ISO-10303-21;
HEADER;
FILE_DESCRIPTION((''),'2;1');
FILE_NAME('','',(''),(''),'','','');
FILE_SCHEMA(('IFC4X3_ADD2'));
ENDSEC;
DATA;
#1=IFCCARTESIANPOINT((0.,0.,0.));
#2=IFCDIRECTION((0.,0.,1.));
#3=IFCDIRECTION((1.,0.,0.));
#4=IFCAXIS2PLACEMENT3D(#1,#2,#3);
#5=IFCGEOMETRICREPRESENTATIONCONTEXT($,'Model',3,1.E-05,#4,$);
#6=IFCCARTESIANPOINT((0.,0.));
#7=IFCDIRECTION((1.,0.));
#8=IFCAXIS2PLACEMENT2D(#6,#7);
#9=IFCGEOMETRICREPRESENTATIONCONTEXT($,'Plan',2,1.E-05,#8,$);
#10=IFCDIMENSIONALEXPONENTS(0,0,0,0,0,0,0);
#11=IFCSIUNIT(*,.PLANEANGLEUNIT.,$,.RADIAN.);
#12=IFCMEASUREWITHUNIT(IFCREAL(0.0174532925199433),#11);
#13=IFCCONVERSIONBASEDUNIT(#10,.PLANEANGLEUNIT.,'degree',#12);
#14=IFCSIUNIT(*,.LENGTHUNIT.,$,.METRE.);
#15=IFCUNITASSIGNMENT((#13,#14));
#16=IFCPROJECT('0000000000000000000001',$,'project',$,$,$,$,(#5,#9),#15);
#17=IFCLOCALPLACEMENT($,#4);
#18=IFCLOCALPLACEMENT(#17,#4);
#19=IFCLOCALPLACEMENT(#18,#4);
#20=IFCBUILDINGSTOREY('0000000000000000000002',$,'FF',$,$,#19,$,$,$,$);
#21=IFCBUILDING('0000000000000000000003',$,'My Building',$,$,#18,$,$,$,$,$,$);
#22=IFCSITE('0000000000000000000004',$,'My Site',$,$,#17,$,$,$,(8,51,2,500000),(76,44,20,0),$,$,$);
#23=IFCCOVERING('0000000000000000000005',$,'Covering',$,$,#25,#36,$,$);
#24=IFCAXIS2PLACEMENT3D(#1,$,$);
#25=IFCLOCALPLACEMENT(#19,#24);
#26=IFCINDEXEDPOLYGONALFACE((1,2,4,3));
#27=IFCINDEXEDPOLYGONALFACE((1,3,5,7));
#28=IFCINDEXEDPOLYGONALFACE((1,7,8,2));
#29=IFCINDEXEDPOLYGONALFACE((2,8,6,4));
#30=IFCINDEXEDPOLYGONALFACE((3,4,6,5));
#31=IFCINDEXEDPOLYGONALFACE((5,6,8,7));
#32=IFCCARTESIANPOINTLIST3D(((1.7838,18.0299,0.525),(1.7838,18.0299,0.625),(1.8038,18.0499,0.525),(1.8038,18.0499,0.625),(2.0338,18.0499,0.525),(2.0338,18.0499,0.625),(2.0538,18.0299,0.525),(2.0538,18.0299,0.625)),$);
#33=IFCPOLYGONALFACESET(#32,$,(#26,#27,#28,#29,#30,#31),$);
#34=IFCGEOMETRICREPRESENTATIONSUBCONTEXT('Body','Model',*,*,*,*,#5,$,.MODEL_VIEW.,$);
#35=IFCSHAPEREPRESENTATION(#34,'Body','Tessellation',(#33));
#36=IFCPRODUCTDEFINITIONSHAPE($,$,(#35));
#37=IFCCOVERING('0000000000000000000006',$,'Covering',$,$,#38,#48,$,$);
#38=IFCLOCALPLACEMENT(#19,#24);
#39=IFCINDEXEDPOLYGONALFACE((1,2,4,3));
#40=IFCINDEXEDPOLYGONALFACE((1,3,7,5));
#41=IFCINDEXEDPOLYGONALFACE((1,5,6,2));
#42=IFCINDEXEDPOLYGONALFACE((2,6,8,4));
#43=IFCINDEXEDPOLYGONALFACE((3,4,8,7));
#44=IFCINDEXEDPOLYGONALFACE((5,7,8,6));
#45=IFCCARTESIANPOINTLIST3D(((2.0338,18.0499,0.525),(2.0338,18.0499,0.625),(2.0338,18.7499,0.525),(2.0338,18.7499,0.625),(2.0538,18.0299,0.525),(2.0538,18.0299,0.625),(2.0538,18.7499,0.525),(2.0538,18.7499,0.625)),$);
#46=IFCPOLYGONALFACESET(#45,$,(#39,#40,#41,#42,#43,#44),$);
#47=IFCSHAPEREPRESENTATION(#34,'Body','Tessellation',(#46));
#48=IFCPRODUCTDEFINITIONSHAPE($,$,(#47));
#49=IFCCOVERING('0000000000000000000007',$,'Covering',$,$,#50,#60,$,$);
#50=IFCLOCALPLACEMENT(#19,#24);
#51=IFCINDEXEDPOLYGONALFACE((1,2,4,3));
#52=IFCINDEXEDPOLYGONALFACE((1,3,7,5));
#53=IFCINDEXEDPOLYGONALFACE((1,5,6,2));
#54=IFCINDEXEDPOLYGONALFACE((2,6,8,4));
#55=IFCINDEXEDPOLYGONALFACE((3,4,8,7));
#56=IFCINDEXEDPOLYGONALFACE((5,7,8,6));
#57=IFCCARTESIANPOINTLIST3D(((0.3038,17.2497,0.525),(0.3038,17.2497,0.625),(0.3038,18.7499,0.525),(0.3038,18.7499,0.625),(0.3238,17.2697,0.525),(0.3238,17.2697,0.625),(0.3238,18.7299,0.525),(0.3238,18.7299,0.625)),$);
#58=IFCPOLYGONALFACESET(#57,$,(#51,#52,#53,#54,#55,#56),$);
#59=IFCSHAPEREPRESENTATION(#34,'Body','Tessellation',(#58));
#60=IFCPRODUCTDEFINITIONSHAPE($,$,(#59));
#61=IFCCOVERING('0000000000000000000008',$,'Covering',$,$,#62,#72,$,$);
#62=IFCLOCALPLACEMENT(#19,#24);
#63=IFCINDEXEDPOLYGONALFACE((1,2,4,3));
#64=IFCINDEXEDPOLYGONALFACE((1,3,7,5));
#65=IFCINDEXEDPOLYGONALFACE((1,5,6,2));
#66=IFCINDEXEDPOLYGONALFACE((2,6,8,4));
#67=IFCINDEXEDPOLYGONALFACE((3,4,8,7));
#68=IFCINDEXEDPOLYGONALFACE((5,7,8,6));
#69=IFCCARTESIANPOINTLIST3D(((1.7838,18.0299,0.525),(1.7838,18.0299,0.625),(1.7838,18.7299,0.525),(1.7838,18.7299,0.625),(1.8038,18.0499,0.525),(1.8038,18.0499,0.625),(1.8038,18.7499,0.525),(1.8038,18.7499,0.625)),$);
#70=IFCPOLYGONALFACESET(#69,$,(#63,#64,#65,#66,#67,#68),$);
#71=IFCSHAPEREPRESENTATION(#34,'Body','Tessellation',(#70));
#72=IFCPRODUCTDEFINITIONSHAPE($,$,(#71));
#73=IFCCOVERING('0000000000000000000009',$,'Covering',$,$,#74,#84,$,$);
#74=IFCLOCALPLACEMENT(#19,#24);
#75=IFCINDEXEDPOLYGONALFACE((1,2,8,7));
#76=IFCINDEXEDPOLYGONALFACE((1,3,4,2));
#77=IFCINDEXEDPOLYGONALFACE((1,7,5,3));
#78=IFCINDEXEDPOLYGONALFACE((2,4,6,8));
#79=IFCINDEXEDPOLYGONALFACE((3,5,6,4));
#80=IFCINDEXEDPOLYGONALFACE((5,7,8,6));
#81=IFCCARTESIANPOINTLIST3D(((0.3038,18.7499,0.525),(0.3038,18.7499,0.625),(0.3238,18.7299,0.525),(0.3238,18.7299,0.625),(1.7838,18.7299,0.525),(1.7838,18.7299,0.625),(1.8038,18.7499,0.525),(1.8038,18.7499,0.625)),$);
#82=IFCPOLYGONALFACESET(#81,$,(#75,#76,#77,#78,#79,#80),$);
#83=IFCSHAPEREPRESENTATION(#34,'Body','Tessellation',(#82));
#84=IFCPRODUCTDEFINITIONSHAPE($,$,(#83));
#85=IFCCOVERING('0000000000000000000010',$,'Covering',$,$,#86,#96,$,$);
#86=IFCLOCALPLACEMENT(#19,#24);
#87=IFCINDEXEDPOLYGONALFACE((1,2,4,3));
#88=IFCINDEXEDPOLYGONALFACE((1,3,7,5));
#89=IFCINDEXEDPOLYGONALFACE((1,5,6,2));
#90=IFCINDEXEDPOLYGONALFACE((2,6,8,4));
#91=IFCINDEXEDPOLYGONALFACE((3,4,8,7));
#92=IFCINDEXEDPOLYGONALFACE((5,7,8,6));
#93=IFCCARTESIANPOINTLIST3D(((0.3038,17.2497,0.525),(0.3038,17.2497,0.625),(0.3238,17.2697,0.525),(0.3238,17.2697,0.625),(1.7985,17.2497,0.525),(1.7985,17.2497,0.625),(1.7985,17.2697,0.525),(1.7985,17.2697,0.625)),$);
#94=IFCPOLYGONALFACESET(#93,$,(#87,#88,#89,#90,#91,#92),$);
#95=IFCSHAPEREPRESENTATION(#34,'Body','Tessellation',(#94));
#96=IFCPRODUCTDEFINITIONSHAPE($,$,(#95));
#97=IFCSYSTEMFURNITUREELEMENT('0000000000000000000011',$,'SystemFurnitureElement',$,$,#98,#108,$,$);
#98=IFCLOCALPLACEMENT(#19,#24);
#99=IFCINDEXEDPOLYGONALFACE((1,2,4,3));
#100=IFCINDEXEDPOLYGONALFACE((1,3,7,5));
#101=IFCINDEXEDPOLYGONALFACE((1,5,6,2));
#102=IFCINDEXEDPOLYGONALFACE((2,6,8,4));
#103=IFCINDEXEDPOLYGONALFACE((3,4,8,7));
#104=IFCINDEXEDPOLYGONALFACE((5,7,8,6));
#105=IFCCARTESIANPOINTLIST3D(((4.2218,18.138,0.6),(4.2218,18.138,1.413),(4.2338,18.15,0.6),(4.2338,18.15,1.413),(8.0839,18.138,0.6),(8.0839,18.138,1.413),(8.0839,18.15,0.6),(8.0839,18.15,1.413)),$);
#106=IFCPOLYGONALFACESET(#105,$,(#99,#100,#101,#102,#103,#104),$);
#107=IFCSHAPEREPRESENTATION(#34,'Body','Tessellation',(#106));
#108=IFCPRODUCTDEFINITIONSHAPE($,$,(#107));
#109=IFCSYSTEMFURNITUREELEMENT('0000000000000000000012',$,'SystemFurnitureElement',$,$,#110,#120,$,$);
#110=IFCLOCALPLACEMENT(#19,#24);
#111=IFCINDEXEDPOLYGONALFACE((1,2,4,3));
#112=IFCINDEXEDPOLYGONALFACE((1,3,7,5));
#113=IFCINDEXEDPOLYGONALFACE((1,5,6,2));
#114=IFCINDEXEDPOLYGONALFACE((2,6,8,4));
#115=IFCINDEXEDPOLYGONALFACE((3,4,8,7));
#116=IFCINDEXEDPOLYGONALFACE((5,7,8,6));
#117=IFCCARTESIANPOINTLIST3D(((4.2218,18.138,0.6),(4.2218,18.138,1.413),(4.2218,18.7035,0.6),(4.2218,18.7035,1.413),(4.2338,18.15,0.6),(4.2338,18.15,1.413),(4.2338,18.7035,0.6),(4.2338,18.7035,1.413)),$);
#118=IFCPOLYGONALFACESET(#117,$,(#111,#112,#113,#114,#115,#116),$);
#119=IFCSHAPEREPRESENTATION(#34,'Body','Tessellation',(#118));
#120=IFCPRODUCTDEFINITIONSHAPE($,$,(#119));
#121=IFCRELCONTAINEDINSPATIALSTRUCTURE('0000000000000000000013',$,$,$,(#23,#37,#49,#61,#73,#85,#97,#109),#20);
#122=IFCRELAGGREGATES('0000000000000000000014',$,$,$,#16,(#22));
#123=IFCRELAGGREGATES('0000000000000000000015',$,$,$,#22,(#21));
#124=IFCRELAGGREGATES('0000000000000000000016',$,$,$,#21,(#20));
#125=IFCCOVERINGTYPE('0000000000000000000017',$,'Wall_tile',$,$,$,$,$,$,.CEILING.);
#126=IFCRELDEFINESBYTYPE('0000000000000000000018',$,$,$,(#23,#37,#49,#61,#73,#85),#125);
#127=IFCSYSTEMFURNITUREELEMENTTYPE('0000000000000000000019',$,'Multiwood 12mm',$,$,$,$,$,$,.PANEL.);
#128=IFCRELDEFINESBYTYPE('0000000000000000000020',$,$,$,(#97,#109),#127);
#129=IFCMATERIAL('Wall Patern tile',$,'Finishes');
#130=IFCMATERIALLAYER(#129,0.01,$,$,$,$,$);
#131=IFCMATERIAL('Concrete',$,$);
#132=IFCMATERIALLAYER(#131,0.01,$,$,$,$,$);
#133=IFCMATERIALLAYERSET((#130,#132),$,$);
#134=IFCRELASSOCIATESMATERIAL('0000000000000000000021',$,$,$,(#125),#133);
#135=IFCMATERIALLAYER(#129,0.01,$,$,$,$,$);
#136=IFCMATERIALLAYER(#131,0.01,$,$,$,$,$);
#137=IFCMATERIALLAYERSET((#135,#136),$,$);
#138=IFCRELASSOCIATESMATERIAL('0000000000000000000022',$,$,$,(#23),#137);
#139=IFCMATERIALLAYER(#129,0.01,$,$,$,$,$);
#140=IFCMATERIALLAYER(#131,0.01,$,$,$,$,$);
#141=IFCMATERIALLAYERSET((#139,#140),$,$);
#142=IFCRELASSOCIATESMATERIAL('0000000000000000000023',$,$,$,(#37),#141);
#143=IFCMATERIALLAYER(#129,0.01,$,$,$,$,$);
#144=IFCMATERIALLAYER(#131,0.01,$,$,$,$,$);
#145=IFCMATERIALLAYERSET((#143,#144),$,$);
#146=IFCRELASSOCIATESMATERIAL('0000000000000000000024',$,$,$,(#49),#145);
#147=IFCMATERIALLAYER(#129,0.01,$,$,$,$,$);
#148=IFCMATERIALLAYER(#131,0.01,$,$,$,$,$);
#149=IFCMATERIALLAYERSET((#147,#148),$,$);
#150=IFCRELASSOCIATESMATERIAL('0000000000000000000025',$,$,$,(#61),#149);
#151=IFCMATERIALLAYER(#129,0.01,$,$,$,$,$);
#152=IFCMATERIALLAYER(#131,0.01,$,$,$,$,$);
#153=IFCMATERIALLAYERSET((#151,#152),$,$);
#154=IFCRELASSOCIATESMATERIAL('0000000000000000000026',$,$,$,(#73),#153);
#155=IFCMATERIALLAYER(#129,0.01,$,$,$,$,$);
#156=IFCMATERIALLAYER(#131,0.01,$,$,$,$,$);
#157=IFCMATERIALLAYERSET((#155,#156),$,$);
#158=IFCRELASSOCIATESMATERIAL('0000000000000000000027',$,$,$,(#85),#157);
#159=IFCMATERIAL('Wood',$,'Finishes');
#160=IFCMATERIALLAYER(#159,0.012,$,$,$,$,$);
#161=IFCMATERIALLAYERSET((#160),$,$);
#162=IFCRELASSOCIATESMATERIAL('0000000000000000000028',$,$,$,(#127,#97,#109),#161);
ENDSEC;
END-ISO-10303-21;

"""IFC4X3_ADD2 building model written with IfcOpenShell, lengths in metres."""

from ifc_helpers import new_model, entity, si_unit, converted_unit, frame, origin_with_axes, origin_2d_with_axis, place, context, subcontext, project, spatial, line, indexed_curve, outline, extrude, material, layer, layer_set, layer_usage, type_object, element, save


model = new_model("IFC4X3_ADD2")

# Units and contexts
model_context = context("Model", 3, precision=1e-05, world=origin_with_axes())
plan_context = context("Plan", 2, precision=1e-05, world=origin_2d_with_axis())
body_context = subcontext(model_context, "Body", "Model", "MODEL_VIEW")
ifc_project = project(units=[converted_unit("PLANEANGLEUNIT", "degree", entity("IfcReal", 0.0174532925199433), si_unit("PLANEANGLEUNIT", "RADIAN"), dimensions=[0, 0, 0, 0, 0, 0, 0]), si_unit("LENGTHUNIT", "METRE")], contexts=[model_context, plan_context])

# Site, building, storey
site_placement = place(None, origin_with_axes())
site = spatial("IfcSite", under=ifc_project, at=site_placement, Name="My Site", RefLatitude=(8, 51, 2, 500000), RefLongitude=(76, 44, 20, 0))
building_placement = place(site_placement, origin_with_axes())
building = spatial("IfcBuilding", under=site, at=building_placement, Name="My Building")
storey_placement = place(building_placement, origin_with_axes())
storey = spatial("IfcBuildingStorey", under=building, at=storey_placement, Name="FF")

# Coverings
ifc_material_1 = material(Name="Wall Patern tile", Category="Finishes")
ifc_layer_1 = layer(ifc_material_1, 0.01)
ifc_material_2 = material(Name="Concrete")
ifc_layer_2 = layer(ifc_material_2, 0.01)
ifc_layer_set_1 = layer_set([ifc_layer_1, ifc_layer_2])
ifc_layer_usage_1 = layer_usage(ifc_layer_set_1, "AXIS2", "NEGATIVE", 0.0)
ifc_layer_3 = layer(ifc_material_1, 0.01)
ifc_layer_4 = layer(ifc_material_2, 0.01)
ifc_layer_set_2 = layer_set([ifc_layer_3, ifc_layer_4])
covering_type_1 = type_object("IfcCoveringType", Name="Wall_tile", PredefinedType="CEILING", material=ifc_layer_set_2)
covering_1_placement = place(storey_placement, frame((2.0538, 18.0299, 0.525), z_axis=(0.0, 0.0, 1.0), x_axis=(-1.0, 0.0, 0.0)))
element("IfcCovering", 1, at=covering_1_placement, inside=storey, type_object=covering_type_1, material=ifc_layer_usage_1, Name="Covering", context=body_context, shape_type="SweptSolid", body=[
    extrude(outline(indexed_curve([(0.02, -0.02), (0.0, 0.0), (0.27, 0.0), (0.25, -0.02)], segments=[line(1, 2, 3, 4, 1)])), origin_with_axes(), (0.0, 0.0, 1.0), 0.1),
])
ifc_layer_5 = layer(ifc_material_1, 0.01)
ifc_layer_6 = layer(ifc_material_2, 0.01)
ifc_layer_set_3 = layer_set([ifc_layer_5, ifc_layer_6])
ifc_layer_usage_2 = layer_usage(ifc_layer_set_3, "AXIS2", "NEGATIVE", 0.0)
covering_2_placement = place(storey_placement, frame((2.0538, 18.7499, 0.525), z_axis=(0.0, 0.0, 1.0), x_axis=(0.0, -1.0, 0.0)))
element("IfcCovering", 2, at=covering_2_placement, inside=storey, type_object=covering_type_1, material=ifc_layer_usage_2, Name="Covering", context=body_context, shape_type="SweptSolid", body=[
    extrude(outline(indexed_curve([(0.0, -0.02), (0.0, 0.0), (0.72, 0.0), (0.7, -0.02)], segments=[line(1, 2, 3, 4, 1)])), origin_with_axes(), (0.0, 0.0, 1.0), 0.1),
])
ifc_layer_7 = layer(ifc_material_1, 0.01)
ifc_layer_8 = layer(ifc_material_2, 0.01)
ifc_layer_set_4 = layer_set([ifc_layer_7, ifc_layer_8])
ifc_layer_usage_3 = layer_usage(ifc_layer_set_4, "AXIS2", "NEGATIVE", 0.0)
covering_3_placement = place(storey_placement, frame((0.3238, 18.7299, 0.525), z_axis=(0.0, 0.0, 1.0), x_axis=(0.0, -1.0, 0.0)))
element("IfcCovering", 3, at=covering_3_placement, inside=storey, type_object=covering_type_1, material=ifc_layer_usage_3, Name="Covering", context=body_context, shape_type="SweptSolid", body=[
    extrude(outline(indexed_curve([(-0.02, -0.02), (0.0, 0.0), (1.4602, 0.0), (1.4802, -0.02)], segments=[line(1, 2, 3, 4, 1)])), origin_with_axes(), (0.0, 0.0, 1.0), 0.1),
])
ifc_layer_9 = layer(ifc_material_1, 0.01)
ifc_layer_10 = layer(ifc_material_2, 0.01)
ifc_layer_set_5 = layer_set([ifc_layer_9, ifc_layer_10])
ifc_layer_usage_4 = layer_usage(ifc_layer_set_5, "AXIS2", "POSITIVE", 0.0)
covering_4_placement = place(storey_placement, frame((1.7838, 18.7299, 0.525), z_axis=(0.0, 0.0, 1.0), x_axis=(0.0, -1.0, 0.0)))
element("IfcCovering", 4, at=covering_4_placement, inside=storey, type_object=covering_type_1, material=ifc_layer_usage_4, Name="Covering", context=body_context, shape_type="SweptSolid", body=[
    extrude(outline(indexed_curve([(0.0, 0.0), (-0.02, 0.02), (0.68, 0.02), (0.7, 0.0)], segments=[line(1, 2, 3, 4, 1)])), origin_with_axes(), (0.0, 0.0, 1.0), 0.1),
])
ifc_layer_11 = layer(ifc_material_1, 0.01)
ifc_layer_12 = layer(ifc_material_2, 0.01)
ifc_layer_set_6 = layer_set([ifc_layer_11, ifc_layer_12])
ifc_layer_usage_5 = layer_usage(ifc_layer_set_6, "AXIS2", "NEGATIVE", 0.0)
covering_5_placement = place(storey_placement, frame((1.7838, 18.7299, 0.525), z_axis=(0.0, 0.0, 1.0), x_axis=(-1.0, 0.0, 0.0)))
element("IfcCovering", 5, at=covering_5_placement, inside=storey, type_object=covering_type_1, material=ifc_layer_usage_5, Name="Covering", context=body_context, shape_type="SweptSolid", body=[
    extrude(outline(indexed_curve([(-0.02, -0.02), (0.0, 0.0), (1.46, 0.0), (1.48, -0.02)], segments=[line(1, 2, 3, 4, 1)])), origin_with_axes(), (0.0, 0.0, 1.0), 0.1),
])
ifc_layer_13 = layer(ifc_material_1, 0.01)
ifc_layer_14 = layer(ifc_material_2, 0.01)
ifc_layer_set_7 = layer_set([ifc_layer_13, ifc_layer_14])
ifc_layer_usage_6 = layer_usage(ifc_layer_set_7, "AXIS2", "POSITIVE", 0.0)
covering_6_placement = place(storey_placement, frame((1.7985, 17.2697, 0.525), z_axis=(0.0, 0.0, 1.0), x_axis=(-1.0, 0.0, 0.0)))
element("IfcCovering", 6, at=covering_6_placement, inside=storey, type_object=covering_type_1, material=ifc_layer_usage_6, Name="Covering", context=body_context, shape_type="SweptSolid", body=[
    extrude(outline(indexed_curve([(0.0, 0.0), (0.0, 0.02), (1.4947, 0.02), (1.4747, 0.0)], segments=[line(1, 2, 3, 4, 1)])), origin_with_axes(), (0.0, 0.0, 1.0), 0.1),
])

# System furniture elements
ifc_material_3 = material(Name="Wood", Category="Finishes")
ifc_layer_15 = layer(ifc_material_3, 0.012)
ifc_layer_set_8 = layer_set([ifc_layer_15])
ifc_layer_usage_7 = layer_usage(ifc_layer_set_8, "AXIS2", "POSITIVE", 0.0)
system_furniture_element_type = type_object("IfcSystemFurnitureElementType", Name="Multiwood 12mm", PredefinedType="PANEL", material=ifc_layer_set_8)
system_furniture_element_1_placement = place(storey_placement, frame((4.2338, 18.138, 0.6), z_axis=(0.0, 0.0, 1.0), x_axis=(1.0, 0.0, 0.0)))
element("IfcSystemFurnitureElement", 7, at=system_furniture_element_1_placement, inside=storey, type_object=system_furniture_element_type, material=ifc_layer_usage_7, Name="SystemFurnitureElement", context=body_context, shape_type="SweptSolid", body=[
    extrude(outline(indexed_curve([(-0.012, 0.0), (0.0, 0.012), (3.85, 0.012), (3.85, 0.0)], segments=[line(1, 2, 3, 4, 1)])), origin_with_axes(), (0.0, 0.0, 1.0), 0.813),
])
ifc_layer_usage_8 = layer_usage(ifc_layer_set_8, "AXIS2", "POSITIVE", 0.0)
system_furniture_element_2_placement = place(storey_placement, frame((4.2338, 18.138, 0.6), z_axis=(0.0, 0.0, 1.0), x_axis=(0.0, 1.0, 0.0)))
element("IfcSystemFurnitureElement", 8, at=system_furniture_element_2_placement, inside=storey, type_object=system_furniture_element_type, material=ifc_layer_usage_8, Name="SystemFurnitureElement", context=body_context, shape_type="SweptSolid", body=[
    extrude(outline(indexed_curve([(0.012, 0.0), (0.0, 0.012), (0.5655, 0.012), (0.5655, 0.0)], segments=[line(1, 2, 3, 4, 1)])), origin_with_axes(), (0.0, 0.0, 1.0), 0.813),
])

save(model, "model.ifc")
